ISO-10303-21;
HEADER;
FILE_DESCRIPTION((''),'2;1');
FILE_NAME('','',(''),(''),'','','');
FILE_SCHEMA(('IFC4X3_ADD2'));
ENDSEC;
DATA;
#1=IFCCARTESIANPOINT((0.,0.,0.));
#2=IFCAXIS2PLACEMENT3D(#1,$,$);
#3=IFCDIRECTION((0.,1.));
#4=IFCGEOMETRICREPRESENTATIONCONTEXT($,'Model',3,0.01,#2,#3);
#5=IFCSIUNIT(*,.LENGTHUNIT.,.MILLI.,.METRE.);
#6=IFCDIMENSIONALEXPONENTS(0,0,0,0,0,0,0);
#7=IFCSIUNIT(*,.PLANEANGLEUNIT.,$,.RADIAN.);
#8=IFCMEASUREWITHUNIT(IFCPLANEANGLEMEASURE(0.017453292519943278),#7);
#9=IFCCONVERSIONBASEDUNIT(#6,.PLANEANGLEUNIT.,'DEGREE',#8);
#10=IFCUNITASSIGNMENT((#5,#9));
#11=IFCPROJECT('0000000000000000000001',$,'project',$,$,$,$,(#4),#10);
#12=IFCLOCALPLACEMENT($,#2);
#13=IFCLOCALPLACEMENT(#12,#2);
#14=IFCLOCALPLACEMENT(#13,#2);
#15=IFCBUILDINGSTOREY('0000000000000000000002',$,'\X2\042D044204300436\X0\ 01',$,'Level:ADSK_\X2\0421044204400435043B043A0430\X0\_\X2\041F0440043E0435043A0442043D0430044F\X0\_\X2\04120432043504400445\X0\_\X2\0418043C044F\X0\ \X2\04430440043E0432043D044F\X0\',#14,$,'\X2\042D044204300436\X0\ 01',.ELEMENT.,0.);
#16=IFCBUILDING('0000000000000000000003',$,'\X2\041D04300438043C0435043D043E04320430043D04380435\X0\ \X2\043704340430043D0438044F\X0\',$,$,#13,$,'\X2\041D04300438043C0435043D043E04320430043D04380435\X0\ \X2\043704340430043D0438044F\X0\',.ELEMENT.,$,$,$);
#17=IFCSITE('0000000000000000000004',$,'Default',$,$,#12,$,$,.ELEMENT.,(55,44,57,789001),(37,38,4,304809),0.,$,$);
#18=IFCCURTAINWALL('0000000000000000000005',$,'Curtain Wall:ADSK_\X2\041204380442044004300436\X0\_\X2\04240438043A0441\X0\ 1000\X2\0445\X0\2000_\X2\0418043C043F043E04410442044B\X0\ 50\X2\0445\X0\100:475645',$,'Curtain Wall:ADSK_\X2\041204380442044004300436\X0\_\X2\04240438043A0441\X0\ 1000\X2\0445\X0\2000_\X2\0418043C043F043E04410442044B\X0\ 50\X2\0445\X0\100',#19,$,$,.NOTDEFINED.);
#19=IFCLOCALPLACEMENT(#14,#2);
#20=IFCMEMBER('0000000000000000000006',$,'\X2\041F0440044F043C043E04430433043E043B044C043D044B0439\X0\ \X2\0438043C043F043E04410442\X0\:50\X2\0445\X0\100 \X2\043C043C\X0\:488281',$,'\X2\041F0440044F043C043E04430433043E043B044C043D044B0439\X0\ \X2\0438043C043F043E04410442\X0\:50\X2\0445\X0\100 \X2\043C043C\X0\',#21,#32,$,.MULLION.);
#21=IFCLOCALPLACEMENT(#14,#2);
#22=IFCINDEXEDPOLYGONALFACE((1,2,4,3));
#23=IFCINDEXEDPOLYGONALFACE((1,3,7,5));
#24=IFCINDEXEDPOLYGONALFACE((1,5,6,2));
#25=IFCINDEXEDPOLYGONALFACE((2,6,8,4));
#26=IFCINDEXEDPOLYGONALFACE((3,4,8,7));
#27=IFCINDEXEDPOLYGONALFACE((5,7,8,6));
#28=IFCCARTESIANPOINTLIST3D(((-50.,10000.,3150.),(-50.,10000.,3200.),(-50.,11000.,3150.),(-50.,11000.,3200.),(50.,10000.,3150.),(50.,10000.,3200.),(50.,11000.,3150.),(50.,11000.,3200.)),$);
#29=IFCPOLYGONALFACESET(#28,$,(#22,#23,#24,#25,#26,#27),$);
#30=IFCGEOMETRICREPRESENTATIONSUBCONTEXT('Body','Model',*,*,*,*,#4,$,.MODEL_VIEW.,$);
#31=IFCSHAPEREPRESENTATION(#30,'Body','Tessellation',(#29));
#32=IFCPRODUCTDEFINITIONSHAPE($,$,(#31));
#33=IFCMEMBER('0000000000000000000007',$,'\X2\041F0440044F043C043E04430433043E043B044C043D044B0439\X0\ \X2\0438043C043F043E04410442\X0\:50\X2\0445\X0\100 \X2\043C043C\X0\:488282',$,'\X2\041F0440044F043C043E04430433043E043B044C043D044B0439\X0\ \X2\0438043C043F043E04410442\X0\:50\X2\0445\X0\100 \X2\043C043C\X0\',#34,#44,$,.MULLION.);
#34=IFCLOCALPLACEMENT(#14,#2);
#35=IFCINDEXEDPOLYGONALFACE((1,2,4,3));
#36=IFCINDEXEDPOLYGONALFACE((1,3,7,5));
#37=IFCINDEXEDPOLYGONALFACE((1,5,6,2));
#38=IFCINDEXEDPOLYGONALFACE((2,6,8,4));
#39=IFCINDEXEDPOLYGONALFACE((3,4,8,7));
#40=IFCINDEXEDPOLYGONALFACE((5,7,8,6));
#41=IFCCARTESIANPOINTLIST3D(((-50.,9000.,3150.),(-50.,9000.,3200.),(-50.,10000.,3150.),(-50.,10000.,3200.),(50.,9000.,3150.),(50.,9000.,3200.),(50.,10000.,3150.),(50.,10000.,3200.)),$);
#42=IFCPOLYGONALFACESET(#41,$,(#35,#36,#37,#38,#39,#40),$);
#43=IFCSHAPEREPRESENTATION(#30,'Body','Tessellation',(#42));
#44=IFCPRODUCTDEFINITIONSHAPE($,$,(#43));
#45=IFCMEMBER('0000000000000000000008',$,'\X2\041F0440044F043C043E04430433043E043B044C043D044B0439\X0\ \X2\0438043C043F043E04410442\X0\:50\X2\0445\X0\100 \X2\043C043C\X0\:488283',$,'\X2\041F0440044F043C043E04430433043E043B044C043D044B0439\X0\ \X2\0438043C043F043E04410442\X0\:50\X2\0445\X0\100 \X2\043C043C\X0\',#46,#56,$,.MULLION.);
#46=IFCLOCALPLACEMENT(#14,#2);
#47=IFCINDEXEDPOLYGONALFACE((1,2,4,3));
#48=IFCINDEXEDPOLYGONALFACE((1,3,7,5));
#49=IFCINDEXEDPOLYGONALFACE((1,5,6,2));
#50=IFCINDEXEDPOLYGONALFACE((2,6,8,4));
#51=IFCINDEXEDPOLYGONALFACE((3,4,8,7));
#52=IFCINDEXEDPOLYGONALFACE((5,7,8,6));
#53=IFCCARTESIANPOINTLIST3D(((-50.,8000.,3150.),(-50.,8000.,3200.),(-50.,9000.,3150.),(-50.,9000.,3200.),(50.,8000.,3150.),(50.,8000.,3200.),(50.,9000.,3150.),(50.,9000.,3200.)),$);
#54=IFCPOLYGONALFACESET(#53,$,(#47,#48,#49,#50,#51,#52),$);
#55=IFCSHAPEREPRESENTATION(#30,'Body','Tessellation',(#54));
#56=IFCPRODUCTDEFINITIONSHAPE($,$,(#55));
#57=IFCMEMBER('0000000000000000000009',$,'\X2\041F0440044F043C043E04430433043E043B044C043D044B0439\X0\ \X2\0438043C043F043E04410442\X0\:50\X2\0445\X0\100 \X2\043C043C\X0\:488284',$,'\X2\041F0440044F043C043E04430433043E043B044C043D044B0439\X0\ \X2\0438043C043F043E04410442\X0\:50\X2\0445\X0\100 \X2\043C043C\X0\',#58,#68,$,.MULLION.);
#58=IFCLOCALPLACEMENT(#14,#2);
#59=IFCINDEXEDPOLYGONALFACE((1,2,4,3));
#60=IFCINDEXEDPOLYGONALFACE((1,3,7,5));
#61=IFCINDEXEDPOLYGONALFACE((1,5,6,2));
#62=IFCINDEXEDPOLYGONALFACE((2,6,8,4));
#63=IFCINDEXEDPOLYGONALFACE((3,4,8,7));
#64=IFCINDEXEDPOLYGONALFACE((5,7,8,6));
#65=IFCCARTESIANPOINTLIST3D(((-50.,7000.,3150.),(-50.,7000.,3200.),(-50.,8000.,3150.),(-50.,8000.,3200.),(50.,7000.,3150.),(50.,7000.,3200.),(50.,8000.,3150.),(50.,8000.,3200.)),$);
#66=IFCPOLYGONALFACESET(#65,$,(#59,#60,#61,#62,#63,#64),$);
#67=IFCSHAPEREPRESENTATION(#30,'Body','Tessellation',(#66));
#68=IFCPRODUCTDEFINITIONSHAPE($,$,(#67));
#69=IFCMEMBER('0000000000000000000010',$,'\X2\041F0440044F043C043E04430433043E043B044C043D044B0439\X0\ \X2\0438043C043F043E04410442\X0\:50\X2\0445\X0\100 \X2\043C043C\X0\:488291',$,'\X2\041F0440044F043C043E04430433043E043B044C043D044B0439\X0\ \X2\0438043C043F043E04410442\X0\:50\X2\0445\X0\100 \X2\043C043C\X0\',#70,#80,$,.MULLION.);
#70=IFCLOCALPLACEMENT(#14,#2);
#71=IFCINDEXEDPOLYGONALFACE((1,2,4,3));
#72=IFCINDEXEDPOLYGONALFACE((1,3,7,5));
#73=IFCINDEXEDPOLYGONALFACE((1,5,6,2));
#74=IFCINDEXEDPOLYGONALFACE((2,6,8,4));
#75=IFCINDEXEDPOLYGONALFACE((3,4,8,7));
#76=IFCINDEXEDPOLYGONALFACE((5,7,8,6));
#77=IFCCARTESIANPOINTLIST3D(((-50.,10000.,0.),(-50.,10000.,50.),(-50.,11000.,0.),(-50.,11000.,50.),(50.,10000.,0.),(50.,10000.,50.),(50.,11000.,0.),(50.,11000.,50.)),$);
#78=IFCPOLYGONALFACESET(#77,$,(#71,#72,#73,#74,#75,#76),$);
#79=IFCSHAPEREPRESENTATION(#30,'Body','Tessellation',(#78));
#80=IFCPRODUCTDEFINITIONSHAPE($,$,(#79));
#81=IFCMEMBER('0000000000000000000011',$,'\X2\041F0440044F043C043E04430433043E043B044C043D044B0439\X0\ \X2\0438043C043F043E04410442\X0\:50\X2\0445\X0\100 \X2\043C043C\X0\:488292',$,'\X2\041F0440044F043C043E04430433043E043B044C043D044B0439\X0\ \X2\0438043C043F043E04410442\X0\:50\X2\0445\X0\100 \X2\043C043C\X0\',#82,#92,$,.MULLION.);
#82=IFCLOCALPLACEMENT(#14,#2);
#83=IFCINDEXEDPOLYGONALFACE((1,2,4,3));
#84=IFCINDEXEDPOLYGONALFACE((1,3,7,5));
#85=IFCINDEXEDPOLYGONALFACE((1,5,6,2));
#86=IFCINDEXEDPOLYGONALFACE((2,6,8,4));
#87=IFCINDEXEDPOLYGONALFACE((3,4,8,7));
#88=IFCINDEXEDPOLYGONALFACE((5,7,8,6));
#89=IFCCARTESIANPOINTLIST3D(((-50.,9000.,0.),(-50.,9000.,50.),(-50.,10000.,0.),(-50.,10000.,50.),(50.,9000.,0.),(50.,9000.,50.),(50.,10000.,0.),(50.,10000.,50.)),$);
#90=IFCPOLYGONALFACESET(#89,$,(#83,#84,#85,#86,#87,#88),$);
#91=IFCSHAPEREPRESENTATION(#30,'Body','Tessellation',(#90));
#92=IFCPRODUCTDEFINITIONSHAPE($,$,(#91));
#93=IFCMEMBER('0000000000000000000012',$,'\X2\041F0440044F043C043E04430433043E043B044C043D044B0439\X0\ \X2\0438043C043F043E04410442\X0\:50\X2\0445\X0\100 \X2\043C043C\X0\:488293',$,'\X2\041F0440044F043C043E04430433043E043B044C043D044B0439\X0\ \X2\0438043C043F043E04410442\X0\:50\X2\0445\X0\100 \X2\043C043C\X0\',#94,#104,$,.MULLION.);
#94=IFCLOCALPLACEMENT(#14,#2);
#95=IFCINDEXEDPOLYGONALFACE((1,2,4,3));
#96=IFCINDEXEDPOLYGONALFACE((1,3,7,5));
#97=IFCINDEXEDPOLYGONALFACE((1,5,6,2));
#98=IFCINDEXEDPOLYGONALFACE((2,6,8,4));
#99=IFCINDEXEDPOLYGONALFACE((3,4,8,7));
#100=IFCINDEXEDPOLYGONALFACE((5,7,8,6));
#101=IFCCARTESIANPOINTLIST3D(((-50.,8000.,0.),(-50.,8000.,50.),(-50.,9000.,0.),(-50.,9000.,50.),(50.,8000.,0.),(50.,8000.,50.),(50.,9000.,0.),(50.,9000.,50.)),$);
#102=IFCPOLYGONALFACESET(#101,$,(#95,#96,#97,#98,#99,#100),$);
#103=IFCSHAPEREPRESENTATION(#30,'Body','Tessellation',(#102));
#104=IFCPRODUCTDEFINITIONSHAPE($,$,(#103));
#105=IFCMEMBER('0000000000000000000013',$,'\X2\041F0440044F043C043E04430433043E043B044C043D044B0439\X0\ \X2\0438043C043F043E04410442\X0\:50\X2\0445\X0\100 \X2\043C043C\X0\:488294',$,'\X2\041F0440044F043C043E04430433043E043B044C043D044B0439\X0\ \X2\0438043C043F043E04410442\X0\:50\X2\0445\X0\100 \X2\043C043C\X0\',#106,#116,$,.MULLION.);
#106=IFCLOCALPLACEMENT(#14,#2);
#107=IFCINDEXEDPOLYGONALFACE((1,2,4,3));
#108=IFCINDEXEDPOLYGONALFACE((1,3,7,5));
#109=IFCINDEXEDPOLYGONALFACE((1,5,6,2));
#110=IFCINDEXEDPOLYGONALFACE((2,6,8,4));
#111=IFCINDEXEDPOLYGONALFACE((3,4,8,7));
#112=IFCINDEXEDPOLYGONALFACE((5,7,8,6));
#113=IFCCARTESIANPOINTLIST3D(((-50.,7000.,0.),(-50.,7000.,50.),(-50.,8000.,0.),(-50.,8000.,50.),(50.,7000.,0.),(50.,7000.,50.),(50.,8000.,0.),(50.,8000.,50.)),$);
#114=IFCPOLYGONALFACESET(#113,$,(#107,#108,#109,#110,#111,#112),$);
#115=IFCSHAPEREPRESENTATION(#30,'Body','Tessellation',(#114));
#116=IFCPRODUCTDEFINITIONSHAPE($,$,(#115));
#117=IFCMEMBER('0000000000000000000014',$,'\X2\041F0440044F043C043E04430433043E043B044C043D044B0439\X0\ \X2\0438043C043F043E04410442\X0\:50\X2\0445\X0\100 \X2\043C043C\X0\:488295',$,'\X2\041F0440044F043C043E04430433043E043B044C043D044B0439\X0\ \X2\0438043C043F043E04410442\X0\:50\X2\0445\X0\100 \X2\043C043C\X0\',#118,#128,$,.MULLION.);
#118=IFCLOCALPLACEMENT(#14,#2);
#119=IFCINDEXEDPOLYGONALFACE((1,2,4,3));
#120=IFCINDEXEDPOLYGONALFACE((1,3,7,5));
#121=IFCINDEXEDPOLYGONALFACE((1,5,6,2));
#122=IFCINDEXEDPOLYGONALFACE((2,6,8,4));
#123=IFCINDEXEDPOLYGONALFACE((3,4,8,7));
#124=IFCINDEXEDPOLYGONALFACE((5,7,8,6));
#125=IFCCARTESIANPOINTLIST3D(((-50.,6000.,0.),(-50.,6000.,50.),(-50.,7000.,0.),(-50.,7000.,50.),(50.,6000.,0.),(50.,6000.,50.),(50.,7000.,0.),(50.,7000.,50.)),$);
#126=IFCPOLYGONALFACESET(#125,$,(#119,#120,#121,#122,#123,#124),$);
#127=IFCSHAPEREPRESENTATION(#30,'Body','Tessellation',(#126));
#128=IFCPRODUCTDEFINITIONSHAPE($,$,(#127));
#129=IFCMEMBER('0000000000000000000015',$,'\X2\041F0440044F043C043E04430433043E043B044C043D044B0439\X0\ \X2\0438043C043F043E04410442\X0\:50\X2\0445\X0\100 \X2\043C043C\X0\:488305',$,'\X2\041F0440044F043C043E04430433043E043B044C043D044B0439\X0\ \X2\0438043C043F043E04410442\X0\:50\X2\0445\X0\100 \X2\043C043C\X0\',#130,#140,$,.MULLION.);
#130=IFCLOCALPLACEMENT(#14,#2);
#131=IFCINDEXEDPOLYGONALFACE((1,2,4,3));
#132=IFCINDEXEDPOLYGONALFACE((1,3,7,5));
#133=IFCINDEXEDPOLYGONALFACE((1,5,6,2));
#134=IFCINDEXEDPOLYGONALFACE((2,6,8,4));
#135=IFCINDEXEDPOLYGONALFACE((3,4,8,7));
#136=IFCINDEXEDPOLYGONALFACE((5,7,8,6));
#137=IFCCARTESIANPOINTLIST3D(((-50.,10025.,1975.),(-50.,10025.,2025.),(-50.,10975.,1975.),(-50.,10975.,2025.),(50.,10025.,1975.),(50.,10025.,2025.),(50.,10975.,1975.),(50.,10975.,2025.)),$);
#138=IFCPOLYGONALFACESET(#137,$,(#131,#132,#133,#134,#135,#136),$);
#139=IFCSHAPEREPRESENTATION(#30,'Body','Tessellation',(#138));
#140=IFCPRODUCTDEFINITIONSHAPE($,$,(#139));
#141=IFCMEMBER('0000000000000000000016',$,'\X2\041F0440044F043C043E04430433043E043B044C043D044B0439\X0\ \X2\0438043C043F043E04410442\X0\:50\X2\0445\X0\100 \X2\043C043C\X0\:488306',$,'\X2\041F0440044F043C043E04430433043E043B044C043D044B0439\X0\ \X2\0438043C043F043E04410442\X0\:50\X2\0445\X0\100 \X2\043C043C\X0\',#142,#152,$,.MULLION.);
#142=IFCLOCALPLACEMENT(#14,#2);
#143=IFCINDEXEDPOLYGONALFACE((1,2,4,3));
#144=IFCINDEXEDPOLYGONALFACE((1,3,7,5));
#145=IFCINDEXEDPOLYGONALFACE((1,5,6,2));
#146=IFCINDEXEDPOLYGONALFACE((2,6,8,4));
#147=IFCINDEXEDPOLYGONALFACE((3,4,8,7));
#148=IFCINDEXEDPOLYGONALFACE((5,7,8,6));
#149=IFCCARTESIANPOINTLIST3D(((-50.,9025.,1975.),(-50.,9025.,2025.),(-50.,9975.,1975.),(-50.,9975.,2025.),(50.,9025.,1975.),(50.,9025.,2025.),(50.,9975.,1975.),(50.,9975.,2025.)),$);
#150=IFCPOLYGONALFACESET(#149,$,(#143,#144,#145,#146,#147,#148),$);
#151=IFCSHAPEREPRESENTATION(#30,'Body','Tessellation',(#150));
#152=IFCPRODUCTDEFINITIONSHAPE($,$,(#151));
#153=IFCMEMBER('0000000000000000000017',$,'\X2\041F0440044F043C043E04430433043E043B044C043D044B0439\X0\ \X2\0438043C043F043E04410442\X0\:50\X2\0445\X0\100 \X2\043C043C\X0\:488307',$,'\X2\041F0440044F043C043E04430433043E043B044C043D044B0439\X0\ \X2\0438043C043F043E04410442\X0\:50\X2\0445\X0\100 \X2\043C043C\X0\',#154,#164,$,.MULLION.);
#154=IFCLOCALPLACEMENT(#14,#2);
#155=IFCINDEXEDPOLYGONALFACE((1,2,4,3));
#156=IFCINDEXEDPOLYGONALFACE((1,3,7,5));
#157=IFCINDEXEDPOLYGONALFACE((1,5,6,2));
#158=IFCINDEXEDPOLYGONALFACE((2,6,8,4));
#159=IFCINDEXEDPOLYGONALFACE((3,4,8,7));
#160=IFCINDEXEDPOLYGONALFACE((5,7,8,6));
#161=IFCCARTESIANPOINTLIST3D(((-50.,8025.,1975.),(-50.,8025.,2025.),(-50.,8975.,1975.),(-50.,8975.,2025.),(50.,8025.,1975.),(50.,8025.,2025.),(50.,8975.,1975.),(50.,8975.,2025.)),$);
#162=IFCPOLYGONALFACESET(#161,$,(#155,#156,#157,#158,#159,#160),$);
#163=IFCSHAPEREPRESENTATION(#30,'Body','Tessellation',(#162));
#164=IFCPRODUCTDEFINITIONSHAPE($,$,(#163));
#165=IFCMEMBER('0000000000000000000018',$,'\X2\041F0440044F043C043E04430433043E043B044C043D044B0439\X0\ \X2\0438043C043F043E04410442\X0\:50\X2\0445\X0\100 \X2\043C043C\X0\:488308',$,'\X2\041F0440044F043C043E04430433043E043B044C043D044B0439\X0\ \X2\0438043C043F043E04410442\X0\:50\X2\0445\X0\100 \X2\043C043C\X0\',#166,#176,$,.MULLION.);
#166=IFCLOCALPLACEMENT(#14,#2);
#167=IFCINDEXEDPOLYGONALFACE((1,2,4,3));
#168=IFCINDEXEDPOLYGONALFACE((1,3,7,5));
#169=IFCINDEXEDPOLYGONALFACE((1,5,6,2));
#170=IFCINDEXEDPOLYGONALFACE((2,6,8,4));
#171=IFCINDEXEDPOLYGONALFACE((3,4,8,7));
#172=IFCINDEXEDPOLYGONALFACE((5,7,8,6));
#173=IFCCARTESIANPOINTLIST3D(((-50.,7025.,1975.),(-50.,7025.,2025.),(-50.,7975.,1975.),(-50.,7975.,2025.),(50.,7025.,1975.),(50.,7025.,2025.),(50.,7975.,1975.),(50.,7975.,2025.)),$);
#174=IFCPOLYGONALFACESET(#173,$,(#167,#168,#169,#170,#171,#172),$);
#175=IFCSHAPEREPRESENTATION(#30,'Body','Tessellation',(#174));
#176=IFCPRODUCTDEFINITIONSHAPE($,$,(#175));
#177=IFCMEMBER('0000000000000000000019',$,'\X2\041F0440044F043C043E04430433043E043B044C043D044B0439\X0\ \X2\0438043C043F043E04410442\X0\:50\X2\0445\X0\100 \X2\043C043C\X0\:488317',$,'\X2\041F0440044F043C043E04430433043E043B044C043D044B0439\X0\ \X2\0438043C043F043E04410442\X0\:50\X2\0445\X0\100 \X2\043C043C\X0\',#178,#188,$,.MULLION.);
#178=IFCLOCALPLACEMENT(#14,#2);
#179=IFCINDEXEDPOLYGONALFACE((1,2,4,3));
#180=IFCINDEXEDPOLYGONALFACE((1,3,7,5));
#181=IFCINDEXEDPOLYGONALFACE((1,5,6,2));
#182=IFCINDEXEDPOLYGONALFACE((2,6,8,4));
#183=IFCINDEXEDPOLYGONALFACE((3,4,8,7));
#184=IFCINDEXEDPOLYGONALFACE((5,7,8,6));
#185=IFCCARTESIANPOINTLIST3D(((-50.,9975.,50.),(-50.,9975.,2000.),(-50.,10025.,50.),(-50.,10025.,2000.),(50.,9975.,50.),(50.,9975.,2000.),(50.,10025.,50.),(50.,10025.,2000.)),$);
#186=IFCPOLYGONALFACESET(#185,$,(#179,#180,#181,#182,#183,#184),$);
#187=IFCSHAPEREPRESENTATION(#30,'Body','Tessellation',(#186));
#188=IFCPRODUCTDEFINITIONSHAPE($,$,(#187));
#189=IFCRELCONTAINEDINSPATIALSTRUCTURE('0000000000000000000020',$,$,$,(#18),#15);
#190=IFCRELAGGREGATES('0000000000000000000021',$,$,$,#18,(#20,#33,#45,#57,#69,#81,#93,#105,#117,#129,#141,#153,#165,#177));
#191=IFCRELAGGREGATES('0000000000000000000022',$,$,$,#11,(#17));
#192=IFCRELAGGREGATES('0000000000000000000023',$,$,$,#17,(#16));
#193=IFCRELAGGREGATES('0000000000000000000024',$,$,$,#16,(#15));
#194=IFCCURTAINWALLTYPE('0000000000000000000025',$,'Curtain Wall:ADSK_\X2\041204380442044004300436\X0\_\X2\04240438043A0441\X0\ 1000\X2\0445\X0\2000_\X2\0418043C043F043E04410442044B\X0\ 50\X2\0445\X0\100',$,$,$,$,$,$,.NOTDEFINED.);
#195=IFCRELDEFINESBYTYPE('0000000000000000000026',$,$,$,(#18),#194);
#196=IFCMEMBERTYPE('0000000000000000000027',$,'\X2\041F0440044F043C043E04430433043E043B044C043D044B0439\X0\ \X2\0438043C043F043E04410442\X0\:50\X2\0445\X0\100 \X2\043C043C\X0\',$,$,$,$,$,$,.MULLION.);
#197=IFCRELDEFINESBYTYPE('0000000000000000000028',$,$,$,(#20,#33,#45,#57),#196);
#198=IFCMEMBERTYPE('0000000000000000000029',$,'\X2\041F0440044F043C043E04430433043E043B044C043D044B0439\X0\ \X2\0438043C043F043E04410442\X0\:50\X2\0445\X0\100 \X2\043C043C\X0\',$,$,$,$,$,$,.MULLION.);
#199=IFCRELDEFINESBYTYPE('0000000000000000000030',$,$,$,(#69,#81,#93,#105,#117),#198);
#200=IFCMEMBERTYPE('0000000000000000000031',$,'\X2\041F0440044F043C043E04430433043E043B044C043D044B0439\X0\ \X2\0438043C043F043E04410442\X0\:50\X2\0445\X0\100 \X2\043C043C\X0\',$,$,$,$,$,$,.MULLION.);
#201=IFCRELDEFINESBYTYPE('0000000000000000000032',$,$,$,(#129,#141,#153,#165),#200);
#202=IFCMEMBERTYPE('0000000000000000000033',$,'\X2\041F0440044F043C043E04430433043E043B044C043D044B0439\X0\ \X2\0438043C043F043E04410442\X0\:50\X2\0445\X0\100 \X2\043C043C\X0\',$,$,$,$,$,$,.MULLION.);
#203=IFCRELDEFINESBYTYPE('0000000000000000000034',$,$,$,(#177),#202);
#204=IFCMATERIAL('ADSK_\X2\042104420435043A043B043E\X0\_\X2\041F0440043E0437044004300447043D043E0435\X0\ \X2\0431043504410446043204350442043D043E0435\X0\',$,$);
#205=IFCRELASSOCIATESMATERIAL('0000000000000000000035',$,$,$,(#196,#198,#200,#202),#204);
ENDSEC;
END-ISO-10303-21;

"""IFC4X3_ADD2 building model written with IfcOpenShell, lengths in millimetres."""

from ifc_helpers import new_model, entity, si_unit, converted_unit, direction, frame, frame_2d, origin, place, context, subcontext, project, spatial, rectangle, extrude, source, transform, mapped, material, material_profile, profile_set, type_object, type_shapes, element, aggregate, save


model = new_model("IFC4X3_ADD2")

# Units and contexts
model_context = context("Model", 3, precision=0.01, world=origin(), true_north=direction((0.0, 1.0)))
body_context = subcontext(model_context, "Body", "Model", "MODEL_VIEW")
ifc_project = project(units=[si_unit("LENGTHUNIT", "METRE", prefix="MILLI"), converted_unit("PLANEANGLEUNIT", "DEGREE", entity("IfcPlaneAngleMeasure", 0.017453292519943278), si_unit("PLANEANGLEUNIT", "RADIAN"), dimensions=[0, 0, 0, 0, 0, 0, 0])], contexts=[model_context])

# Site, building, storey
site_placement = place(None, origin())
site = spatial("IfcSite", under=ifc_project, at=site_placement, Name="Default", CompositionType="ELEMENT", RefLatitude=(55, 44, 57, 789001), RefLongitude=(37, 38, 4, 304809), RefElevation=0.0)
building_placement = place(site_placement, origin())
building = spatial("IfcBuilding", under=site, at=building_placement, Name="Наименование здания", LongName="Наименование здания", CompositionType="ELEMENT")
storey_placement = place(building_placement, origin())
storey = spatial("IfcBuildingStorey", under=building, at=storey_placement, Name="Этаж 01", ObjectType="Level:ADSK_Стрелка_Проектная_Вверх_Имя уровня", LongName="Этаж 01", CompositionType="ELEMENT", Elevation=0.0)

# Curtain wall, members
curtain_wall_type = type_object("IfcCurtainWallType", Name="Curtain Wall:ADSK_Витраж_Фикс 1000х2000_Импосты 50х100", PredefinedType="NOTDEFINED")
curtain_wall_placement = place(storey_placement, origin())
curtain_wall = element("IfcCurtainWall", 1, at=curtain_wall_placement, inside=storey, type_object=curtain_wall_type, Name="Curtain Wall:ADSK_Витраж_Фикс 1000х2000_Импосты 50х100:475645", ObjectType="Curtain Wall:ADSK_Витраж_Фикс 1000х2000_Импосты 50х100", PredefinedType="NOTDEFINED")
ifc_material = material(Name="ADSK_Стекло_Прозрачное бесцветное")
ifc_material_profile = material_profile(ifc_material, rectangle(XDim=50.0, YDim=100.0, at=frame_2d((0.0, 0.0), x_axis=(1.0, 0.0))), Name="50х100 мм")
ifc_profile_set = profile_set([ifc_material_profile], Name="50х100 мм")
member_type_1 = type_object("IfcMemberType", Name="Прямоугольный импост:50х100 мм", PredefinedType="MULLION", material=ifc_profile_set)
shared_shape_1 = source(origin(), body_context, "Body", "SweptSolid", [
    extrude(rectangle(XDim=50.0, YDim=100.0, at=frame_2d((0.0, 0.0), x_axis=(1.0, 0.0))), frame((-25.0, 0.0, -1000.0), z_axis=(0.0, 0.0, 1.0), x_axis=(-1.0, 0.0, 0.0)), (0.0, 0.0, 1.0), 1000.0),
])
type_shapes(member_type_1, [shared_shape_1])
member_1_placement = place(curtain_wall_placement, frame((0.0, 10000.0, 3200.0), z_axis=(0.0, -1.0, 0.0), x_axis=(0.0, 0.0, 1.0)))
member_1 = element("IfcMember", 2, at=member_1_placement, type_object=member_type_1, Name="Прямоугольный импост:50х100 мм:488281", ObjectType="Прямоугольный импост:50х100 мм", PredefinedType="MULLION", context=body_context, shape_type="MappedRepresentation", body=[
    mapped(shared_shape_1, transform((0.0, 0.0, 0.0), scale=1.0)),
])
member_2_placement = place(curtain_wall_placement, frame((0.0, 9000.0, 3200.0), z_axis=(0.0, -1.0, 0.0), x_axis=(0.0, 0.0, 1.0)))
member_2 = element("IfcMember", 3, at=member_2_placement, type_object=member_type_1, Name="Прямоугольный импост:50х100 мм:488282", ObjectType="Прямоугольный импост:50х100 мм", PredefinedType="MULLION", context=body_context, shape_type="MappedRepresentation", body=[
    mapped(shared_shape_1, transform((0.0, 0.0, 0.0), scale=1.0)),
])
member_3_placement = place(curtain_wall_placement, frame((0.0, 8000.0, 3200.0), z_axis=(0.0, -1.0, 0.0), x_axis=(0.0, 0.0, 1.0)))
member_3 = element("IfcMember", 4, at=member_3_placement, type_object=member_type_1, Name="Прямоугольный импост:50х100 мм:488283", ObjectType="Прямоугольный импост:50х100 мм", PredefinedType="MULLION", context=body_context, shape_type="MappedRepresentation", body=[
    mapped(shared_shape_1, transform((0.0, 0.0, 0.0), scale=1.0)),
])
member_4_placement = place(curtain_wall_placement, frame((0.0, 7000.0, 3200.0), z_axis=(0.0, -1.0, 0.0), x_axis=(0.0, 0.0, 1.0)))
member_4 = element("IfcMember", 5, at=member_4_placement, type_object=member_type_1, Name="Прямоугольный импост:50х100 мм:488284", ObjectType="Прямоугольный импост:50х100 мм", PredefinedType="MULLION", context=body_context, shape_type="MappedRepresentation", body=[
    mapped(shared_shape_1, transform((0.0, 0.0, 0.0), scale=1.0)),
])
member_type_2 = type_object("IfcMemberType", Name="Прямоугольный импост:50х100 мм", PredefinedType="MULLION", material=ifc_profile_set)
shared_shape_2 = source(origin(), body_context, "Body", "SweptSolid", [
    extrude(rectangle(XDim=50.0, YDim=100.0, at=frame_2d((0.0, 0.0), x_axis=(1.0, 0.0))), frame((-25.0, 0.0, -1000.0), z_axis=(0.0, 0.0, 1.0), x_axis=(-1.0, 0.0, 0.0)), (0.0, 0.0, 1.0), 1000.0),
])
type_shapes(member_type_2, [shared_shape_2])
member_5_placement = place(curtain_wall_placement, frame((0.0, 11000.0, 0.0), z_axis=(0.0, 1.0, 0.0), x_axis=(0.0, 0.0, -1.0)))
member_5 = element("IfcMember", 6, at=member_5_placement, type_object=member_type_2, Name="Прямоугольный импост:50х100 мм:488291", ObjectType="Прямоугольный импост:50х100 мм", PredefinedType="MULLION", context=body_context, shape_type="MappedRepresentation", body=[
    mapped(shared_shape_2, transform((0.0, 0.0, 0.0), scale=1.0)),
])
member_6_placement = place(curtain_wall_placement, frame((0.0, 10000.0, 0.0), z_axis=(0.0, 1.0, 0.0), x_axis=(0.0, 0.0, -1.0)))
member_6 = element("IfcMember", 7, at=member_6_placement, type_object=member_type_2, Name="Прямоугольный импост:50х100 мм:488292", ObjectType="Прямоугольный импост:50х100 мм", PredefinedType="MULLION", context=body_context, shape_type="MappedRepresentation", body=[
    mapped(shared_shape_2, transform((0.0, 0.0, 0.0), scale=1.0)),
])
member_7_placement = place(curtain_wall_placement, frame((0.0, 9000.0, 0.0), z_axis=(0.0, 1.0, 0.0), x_axis=(0.0, 0.0, -1.0)))
member_7 = element("IfcMember", 8, at=member_7_placement, type_object=member_type_2, Name="Прямоугольный импост:50х100 мм:488293", ObjectType="Прямоугольный импост:50х100 мм", PredefinedType="MULLION", context=body_context, shape_type="MappedRepresentation", body=[
    mapped(shared_shape_2, transform((0.0, 0.0, 0.0), scale=1.0)),
])
member_8_placement = place(curtain_wall_placement, frame((0.0, 8000.0, 0.0), z_axis=(0.0, 1.0, 0.0), x_axis=(0.0, 0.0, -1.0)))
member_8 = element("IfcMember", 9, at=member_8_placement, type_object=member_type_2, Name="Прямоугольный импост:50х100 мм:488294", ObjectType="Прямоугольный импост:50х100 мм", PredefinedType="MULLION", context=body_context, shape_type="MappedRepresentation", body=[
    mapped(shared_shape_2, transform((0.0, 0.0, 0.0), scale=1.0)),
])
member_9_placement = place(curtain_wall_placement, frame((0.0, 7000.0, 0.0), z_axis=(0.0, 1.0, 0.0), x_axis=(0.0, 0.0, -1.0)))
member_9 = element("IfcMember", 10, at=member_9_placement, type_object=member_type_2, Name="Прямоугольный импост:50х100 мм:488295", ObjectType="Прямоугольный импост:50х100 мм", PredefinedType="MULLION", context=body_context, shape_type="MappedRepresentation", body=[
    mapped(shared_shape_2, transform((0.0, 0.0, 0.0), scale=1.0)),
])
member_type_3 = type_object("IfcMemberType", Name="Прямоугольный импост:50х100 мм", PredefinedType="MULLION", material=ifc_profile_set)
shared_shape_3 = source(origin(), body_context, "Body", "SweptSolid", [
    extrude(rectangle(XDim=50.0, YDim=100.0, at=frame_2d((0.0, 0.0), x_axis=(1.0, 0.0))), frame((0.0, 0.0, -950.0), z_axis=(0.0, 0.0, 1.0), x_axis=(-1.0, 0.0, 0.0)), (0.0, 0.0, 1.0), 950.0),
])
type_shapes(member_type_3, [shared_shape_3])
member_10_placement = place(curtain_wall_placement, frame((0.0, 10025.0, 2000.0), z_axis=(0.0, -1.0, 0.0), x_axis=(0.0, 0.0, 1.0)))
member_10 = element("IfcMember", 11, at=member_10_placement, type_object=member_type_3, Name="Прямоугольный импост:50х100 мм:488305", ObjectType="Прямоугольный импост:50х100 мм", PredefinedType="MULLION", context=body_context, shape_type="MappedRepresentation", body=[
    mapped(shared_shape_3, transform((0.0, 0.0, 0.0), scale=1.0)),
])
member_11_placement = place(curtain_wall_placement, frame((0.0, 9025.0, 2000.0), z_axis=(0.0, -1.0, 0.0), x_axis=(0.0, 0.0, 1.0)))
member_11 = element("IfcMember", 12, at=member_11_placement, type_object=member_type_3, Name="Прямоугольный импост:50х100 мм:488306", ObjectType="Прямоугольный импост:50х100 мм", PredefinedType="MULLION", context=body_context, shape_type="MappedRepresentation", body=[
    mapped(shared_shape_3, transform((0.0, 0.0, 0.0), scale=1.0)),
])
member_12_placement = place(curtain_wall_placement, frame((0.0, 8025.0, 2000.0), z_axis=(0.0, -1.0, 0.0), x_axis=(0.0, 0.0, 1.0)))
member_12 = element("IfcMember", 13, at=member_12_placement, type_object=member_type_3, Name="Прямоугольный импост:50х100 мм:488307", ObjectType="Прямоугольный импост:50х100 мм", PredefinedType="MULLION", context=body_context, shape_type="MappedRepresentation", body=[
    mapped(shared_shape_3, transform((0.0, 0.0, 0.0), scale=1.0)),
])
member_13_placement = place(curtain_wall_placement, frame((0.0, 7025.0, 2000.0), z_axis=(0.0, -1.0, 0.0), x_axis=(0.0, 0.0, 1.0)))
member_13 = element("IfcMember", 14, at=member_13_placement, type_object=member_type_3, Name="Прямоугольный импост:50х100 мм:488308", ObjectType="Прямоугольный импост:50х100 мм", PredefinedType="MULLION", context=body_context, shape_type="MappedRepresentation", body=[
    mapped(shared_shape_3, transform((0.0, 0.0, 0.0), scale=1.0)),
])
member_type_4 = type_object("IfcMemberType", Name="Прямоугольный импост:50х100 мм", PredefinedType="MULLION", material=ifc_profile_set)
shared_shape_4 = source(origin(), body_context, "Body", "SweptSolid", [
    extrude(rectangle(XDim=50.0, YDim=100.0, at=frame_2d((0.0, 0.0), x_axis=(1.0, 0.0))), frame((0.0, 0.0, -1950.0), z_axis=(0.0, 0.0, 1.0), x_axis=(-1.0, 0.0, 0.0)), (0.0, 0.0, 1.0), 1950.0),
])
type_shapes(member_type_4, [shared_shape_4])
member_14_placement = place(curtain_wall_placement, frame((0.0, 10000.0, 50.0), z_axis=(0.0, 0.0, -1.0), x_axis=(0.0, -1.0, 0.0)))
member_14 = element("IfcMember", 15, at=member_14_placement, type_object=member_type_4, Name="Прямоугольный импост:50х100 мм:488317", ObjectType="Прямоугольный импост:50х100 мм", PredefinedType="MULLION", context=body_context, shape_type="MappedRepresentation", body=[
    mapped(shared_shape_4, transform((0.0, 0.0, 0.0), scale=1.0)),
])
aggregate(curtain_wall, [member_1, member_2, member_3, member_4, member_5, member_6, member_7, member_8, member_9, member_10, member_11, member_12, member_13, member_14])

save(model, "model.ifc")
